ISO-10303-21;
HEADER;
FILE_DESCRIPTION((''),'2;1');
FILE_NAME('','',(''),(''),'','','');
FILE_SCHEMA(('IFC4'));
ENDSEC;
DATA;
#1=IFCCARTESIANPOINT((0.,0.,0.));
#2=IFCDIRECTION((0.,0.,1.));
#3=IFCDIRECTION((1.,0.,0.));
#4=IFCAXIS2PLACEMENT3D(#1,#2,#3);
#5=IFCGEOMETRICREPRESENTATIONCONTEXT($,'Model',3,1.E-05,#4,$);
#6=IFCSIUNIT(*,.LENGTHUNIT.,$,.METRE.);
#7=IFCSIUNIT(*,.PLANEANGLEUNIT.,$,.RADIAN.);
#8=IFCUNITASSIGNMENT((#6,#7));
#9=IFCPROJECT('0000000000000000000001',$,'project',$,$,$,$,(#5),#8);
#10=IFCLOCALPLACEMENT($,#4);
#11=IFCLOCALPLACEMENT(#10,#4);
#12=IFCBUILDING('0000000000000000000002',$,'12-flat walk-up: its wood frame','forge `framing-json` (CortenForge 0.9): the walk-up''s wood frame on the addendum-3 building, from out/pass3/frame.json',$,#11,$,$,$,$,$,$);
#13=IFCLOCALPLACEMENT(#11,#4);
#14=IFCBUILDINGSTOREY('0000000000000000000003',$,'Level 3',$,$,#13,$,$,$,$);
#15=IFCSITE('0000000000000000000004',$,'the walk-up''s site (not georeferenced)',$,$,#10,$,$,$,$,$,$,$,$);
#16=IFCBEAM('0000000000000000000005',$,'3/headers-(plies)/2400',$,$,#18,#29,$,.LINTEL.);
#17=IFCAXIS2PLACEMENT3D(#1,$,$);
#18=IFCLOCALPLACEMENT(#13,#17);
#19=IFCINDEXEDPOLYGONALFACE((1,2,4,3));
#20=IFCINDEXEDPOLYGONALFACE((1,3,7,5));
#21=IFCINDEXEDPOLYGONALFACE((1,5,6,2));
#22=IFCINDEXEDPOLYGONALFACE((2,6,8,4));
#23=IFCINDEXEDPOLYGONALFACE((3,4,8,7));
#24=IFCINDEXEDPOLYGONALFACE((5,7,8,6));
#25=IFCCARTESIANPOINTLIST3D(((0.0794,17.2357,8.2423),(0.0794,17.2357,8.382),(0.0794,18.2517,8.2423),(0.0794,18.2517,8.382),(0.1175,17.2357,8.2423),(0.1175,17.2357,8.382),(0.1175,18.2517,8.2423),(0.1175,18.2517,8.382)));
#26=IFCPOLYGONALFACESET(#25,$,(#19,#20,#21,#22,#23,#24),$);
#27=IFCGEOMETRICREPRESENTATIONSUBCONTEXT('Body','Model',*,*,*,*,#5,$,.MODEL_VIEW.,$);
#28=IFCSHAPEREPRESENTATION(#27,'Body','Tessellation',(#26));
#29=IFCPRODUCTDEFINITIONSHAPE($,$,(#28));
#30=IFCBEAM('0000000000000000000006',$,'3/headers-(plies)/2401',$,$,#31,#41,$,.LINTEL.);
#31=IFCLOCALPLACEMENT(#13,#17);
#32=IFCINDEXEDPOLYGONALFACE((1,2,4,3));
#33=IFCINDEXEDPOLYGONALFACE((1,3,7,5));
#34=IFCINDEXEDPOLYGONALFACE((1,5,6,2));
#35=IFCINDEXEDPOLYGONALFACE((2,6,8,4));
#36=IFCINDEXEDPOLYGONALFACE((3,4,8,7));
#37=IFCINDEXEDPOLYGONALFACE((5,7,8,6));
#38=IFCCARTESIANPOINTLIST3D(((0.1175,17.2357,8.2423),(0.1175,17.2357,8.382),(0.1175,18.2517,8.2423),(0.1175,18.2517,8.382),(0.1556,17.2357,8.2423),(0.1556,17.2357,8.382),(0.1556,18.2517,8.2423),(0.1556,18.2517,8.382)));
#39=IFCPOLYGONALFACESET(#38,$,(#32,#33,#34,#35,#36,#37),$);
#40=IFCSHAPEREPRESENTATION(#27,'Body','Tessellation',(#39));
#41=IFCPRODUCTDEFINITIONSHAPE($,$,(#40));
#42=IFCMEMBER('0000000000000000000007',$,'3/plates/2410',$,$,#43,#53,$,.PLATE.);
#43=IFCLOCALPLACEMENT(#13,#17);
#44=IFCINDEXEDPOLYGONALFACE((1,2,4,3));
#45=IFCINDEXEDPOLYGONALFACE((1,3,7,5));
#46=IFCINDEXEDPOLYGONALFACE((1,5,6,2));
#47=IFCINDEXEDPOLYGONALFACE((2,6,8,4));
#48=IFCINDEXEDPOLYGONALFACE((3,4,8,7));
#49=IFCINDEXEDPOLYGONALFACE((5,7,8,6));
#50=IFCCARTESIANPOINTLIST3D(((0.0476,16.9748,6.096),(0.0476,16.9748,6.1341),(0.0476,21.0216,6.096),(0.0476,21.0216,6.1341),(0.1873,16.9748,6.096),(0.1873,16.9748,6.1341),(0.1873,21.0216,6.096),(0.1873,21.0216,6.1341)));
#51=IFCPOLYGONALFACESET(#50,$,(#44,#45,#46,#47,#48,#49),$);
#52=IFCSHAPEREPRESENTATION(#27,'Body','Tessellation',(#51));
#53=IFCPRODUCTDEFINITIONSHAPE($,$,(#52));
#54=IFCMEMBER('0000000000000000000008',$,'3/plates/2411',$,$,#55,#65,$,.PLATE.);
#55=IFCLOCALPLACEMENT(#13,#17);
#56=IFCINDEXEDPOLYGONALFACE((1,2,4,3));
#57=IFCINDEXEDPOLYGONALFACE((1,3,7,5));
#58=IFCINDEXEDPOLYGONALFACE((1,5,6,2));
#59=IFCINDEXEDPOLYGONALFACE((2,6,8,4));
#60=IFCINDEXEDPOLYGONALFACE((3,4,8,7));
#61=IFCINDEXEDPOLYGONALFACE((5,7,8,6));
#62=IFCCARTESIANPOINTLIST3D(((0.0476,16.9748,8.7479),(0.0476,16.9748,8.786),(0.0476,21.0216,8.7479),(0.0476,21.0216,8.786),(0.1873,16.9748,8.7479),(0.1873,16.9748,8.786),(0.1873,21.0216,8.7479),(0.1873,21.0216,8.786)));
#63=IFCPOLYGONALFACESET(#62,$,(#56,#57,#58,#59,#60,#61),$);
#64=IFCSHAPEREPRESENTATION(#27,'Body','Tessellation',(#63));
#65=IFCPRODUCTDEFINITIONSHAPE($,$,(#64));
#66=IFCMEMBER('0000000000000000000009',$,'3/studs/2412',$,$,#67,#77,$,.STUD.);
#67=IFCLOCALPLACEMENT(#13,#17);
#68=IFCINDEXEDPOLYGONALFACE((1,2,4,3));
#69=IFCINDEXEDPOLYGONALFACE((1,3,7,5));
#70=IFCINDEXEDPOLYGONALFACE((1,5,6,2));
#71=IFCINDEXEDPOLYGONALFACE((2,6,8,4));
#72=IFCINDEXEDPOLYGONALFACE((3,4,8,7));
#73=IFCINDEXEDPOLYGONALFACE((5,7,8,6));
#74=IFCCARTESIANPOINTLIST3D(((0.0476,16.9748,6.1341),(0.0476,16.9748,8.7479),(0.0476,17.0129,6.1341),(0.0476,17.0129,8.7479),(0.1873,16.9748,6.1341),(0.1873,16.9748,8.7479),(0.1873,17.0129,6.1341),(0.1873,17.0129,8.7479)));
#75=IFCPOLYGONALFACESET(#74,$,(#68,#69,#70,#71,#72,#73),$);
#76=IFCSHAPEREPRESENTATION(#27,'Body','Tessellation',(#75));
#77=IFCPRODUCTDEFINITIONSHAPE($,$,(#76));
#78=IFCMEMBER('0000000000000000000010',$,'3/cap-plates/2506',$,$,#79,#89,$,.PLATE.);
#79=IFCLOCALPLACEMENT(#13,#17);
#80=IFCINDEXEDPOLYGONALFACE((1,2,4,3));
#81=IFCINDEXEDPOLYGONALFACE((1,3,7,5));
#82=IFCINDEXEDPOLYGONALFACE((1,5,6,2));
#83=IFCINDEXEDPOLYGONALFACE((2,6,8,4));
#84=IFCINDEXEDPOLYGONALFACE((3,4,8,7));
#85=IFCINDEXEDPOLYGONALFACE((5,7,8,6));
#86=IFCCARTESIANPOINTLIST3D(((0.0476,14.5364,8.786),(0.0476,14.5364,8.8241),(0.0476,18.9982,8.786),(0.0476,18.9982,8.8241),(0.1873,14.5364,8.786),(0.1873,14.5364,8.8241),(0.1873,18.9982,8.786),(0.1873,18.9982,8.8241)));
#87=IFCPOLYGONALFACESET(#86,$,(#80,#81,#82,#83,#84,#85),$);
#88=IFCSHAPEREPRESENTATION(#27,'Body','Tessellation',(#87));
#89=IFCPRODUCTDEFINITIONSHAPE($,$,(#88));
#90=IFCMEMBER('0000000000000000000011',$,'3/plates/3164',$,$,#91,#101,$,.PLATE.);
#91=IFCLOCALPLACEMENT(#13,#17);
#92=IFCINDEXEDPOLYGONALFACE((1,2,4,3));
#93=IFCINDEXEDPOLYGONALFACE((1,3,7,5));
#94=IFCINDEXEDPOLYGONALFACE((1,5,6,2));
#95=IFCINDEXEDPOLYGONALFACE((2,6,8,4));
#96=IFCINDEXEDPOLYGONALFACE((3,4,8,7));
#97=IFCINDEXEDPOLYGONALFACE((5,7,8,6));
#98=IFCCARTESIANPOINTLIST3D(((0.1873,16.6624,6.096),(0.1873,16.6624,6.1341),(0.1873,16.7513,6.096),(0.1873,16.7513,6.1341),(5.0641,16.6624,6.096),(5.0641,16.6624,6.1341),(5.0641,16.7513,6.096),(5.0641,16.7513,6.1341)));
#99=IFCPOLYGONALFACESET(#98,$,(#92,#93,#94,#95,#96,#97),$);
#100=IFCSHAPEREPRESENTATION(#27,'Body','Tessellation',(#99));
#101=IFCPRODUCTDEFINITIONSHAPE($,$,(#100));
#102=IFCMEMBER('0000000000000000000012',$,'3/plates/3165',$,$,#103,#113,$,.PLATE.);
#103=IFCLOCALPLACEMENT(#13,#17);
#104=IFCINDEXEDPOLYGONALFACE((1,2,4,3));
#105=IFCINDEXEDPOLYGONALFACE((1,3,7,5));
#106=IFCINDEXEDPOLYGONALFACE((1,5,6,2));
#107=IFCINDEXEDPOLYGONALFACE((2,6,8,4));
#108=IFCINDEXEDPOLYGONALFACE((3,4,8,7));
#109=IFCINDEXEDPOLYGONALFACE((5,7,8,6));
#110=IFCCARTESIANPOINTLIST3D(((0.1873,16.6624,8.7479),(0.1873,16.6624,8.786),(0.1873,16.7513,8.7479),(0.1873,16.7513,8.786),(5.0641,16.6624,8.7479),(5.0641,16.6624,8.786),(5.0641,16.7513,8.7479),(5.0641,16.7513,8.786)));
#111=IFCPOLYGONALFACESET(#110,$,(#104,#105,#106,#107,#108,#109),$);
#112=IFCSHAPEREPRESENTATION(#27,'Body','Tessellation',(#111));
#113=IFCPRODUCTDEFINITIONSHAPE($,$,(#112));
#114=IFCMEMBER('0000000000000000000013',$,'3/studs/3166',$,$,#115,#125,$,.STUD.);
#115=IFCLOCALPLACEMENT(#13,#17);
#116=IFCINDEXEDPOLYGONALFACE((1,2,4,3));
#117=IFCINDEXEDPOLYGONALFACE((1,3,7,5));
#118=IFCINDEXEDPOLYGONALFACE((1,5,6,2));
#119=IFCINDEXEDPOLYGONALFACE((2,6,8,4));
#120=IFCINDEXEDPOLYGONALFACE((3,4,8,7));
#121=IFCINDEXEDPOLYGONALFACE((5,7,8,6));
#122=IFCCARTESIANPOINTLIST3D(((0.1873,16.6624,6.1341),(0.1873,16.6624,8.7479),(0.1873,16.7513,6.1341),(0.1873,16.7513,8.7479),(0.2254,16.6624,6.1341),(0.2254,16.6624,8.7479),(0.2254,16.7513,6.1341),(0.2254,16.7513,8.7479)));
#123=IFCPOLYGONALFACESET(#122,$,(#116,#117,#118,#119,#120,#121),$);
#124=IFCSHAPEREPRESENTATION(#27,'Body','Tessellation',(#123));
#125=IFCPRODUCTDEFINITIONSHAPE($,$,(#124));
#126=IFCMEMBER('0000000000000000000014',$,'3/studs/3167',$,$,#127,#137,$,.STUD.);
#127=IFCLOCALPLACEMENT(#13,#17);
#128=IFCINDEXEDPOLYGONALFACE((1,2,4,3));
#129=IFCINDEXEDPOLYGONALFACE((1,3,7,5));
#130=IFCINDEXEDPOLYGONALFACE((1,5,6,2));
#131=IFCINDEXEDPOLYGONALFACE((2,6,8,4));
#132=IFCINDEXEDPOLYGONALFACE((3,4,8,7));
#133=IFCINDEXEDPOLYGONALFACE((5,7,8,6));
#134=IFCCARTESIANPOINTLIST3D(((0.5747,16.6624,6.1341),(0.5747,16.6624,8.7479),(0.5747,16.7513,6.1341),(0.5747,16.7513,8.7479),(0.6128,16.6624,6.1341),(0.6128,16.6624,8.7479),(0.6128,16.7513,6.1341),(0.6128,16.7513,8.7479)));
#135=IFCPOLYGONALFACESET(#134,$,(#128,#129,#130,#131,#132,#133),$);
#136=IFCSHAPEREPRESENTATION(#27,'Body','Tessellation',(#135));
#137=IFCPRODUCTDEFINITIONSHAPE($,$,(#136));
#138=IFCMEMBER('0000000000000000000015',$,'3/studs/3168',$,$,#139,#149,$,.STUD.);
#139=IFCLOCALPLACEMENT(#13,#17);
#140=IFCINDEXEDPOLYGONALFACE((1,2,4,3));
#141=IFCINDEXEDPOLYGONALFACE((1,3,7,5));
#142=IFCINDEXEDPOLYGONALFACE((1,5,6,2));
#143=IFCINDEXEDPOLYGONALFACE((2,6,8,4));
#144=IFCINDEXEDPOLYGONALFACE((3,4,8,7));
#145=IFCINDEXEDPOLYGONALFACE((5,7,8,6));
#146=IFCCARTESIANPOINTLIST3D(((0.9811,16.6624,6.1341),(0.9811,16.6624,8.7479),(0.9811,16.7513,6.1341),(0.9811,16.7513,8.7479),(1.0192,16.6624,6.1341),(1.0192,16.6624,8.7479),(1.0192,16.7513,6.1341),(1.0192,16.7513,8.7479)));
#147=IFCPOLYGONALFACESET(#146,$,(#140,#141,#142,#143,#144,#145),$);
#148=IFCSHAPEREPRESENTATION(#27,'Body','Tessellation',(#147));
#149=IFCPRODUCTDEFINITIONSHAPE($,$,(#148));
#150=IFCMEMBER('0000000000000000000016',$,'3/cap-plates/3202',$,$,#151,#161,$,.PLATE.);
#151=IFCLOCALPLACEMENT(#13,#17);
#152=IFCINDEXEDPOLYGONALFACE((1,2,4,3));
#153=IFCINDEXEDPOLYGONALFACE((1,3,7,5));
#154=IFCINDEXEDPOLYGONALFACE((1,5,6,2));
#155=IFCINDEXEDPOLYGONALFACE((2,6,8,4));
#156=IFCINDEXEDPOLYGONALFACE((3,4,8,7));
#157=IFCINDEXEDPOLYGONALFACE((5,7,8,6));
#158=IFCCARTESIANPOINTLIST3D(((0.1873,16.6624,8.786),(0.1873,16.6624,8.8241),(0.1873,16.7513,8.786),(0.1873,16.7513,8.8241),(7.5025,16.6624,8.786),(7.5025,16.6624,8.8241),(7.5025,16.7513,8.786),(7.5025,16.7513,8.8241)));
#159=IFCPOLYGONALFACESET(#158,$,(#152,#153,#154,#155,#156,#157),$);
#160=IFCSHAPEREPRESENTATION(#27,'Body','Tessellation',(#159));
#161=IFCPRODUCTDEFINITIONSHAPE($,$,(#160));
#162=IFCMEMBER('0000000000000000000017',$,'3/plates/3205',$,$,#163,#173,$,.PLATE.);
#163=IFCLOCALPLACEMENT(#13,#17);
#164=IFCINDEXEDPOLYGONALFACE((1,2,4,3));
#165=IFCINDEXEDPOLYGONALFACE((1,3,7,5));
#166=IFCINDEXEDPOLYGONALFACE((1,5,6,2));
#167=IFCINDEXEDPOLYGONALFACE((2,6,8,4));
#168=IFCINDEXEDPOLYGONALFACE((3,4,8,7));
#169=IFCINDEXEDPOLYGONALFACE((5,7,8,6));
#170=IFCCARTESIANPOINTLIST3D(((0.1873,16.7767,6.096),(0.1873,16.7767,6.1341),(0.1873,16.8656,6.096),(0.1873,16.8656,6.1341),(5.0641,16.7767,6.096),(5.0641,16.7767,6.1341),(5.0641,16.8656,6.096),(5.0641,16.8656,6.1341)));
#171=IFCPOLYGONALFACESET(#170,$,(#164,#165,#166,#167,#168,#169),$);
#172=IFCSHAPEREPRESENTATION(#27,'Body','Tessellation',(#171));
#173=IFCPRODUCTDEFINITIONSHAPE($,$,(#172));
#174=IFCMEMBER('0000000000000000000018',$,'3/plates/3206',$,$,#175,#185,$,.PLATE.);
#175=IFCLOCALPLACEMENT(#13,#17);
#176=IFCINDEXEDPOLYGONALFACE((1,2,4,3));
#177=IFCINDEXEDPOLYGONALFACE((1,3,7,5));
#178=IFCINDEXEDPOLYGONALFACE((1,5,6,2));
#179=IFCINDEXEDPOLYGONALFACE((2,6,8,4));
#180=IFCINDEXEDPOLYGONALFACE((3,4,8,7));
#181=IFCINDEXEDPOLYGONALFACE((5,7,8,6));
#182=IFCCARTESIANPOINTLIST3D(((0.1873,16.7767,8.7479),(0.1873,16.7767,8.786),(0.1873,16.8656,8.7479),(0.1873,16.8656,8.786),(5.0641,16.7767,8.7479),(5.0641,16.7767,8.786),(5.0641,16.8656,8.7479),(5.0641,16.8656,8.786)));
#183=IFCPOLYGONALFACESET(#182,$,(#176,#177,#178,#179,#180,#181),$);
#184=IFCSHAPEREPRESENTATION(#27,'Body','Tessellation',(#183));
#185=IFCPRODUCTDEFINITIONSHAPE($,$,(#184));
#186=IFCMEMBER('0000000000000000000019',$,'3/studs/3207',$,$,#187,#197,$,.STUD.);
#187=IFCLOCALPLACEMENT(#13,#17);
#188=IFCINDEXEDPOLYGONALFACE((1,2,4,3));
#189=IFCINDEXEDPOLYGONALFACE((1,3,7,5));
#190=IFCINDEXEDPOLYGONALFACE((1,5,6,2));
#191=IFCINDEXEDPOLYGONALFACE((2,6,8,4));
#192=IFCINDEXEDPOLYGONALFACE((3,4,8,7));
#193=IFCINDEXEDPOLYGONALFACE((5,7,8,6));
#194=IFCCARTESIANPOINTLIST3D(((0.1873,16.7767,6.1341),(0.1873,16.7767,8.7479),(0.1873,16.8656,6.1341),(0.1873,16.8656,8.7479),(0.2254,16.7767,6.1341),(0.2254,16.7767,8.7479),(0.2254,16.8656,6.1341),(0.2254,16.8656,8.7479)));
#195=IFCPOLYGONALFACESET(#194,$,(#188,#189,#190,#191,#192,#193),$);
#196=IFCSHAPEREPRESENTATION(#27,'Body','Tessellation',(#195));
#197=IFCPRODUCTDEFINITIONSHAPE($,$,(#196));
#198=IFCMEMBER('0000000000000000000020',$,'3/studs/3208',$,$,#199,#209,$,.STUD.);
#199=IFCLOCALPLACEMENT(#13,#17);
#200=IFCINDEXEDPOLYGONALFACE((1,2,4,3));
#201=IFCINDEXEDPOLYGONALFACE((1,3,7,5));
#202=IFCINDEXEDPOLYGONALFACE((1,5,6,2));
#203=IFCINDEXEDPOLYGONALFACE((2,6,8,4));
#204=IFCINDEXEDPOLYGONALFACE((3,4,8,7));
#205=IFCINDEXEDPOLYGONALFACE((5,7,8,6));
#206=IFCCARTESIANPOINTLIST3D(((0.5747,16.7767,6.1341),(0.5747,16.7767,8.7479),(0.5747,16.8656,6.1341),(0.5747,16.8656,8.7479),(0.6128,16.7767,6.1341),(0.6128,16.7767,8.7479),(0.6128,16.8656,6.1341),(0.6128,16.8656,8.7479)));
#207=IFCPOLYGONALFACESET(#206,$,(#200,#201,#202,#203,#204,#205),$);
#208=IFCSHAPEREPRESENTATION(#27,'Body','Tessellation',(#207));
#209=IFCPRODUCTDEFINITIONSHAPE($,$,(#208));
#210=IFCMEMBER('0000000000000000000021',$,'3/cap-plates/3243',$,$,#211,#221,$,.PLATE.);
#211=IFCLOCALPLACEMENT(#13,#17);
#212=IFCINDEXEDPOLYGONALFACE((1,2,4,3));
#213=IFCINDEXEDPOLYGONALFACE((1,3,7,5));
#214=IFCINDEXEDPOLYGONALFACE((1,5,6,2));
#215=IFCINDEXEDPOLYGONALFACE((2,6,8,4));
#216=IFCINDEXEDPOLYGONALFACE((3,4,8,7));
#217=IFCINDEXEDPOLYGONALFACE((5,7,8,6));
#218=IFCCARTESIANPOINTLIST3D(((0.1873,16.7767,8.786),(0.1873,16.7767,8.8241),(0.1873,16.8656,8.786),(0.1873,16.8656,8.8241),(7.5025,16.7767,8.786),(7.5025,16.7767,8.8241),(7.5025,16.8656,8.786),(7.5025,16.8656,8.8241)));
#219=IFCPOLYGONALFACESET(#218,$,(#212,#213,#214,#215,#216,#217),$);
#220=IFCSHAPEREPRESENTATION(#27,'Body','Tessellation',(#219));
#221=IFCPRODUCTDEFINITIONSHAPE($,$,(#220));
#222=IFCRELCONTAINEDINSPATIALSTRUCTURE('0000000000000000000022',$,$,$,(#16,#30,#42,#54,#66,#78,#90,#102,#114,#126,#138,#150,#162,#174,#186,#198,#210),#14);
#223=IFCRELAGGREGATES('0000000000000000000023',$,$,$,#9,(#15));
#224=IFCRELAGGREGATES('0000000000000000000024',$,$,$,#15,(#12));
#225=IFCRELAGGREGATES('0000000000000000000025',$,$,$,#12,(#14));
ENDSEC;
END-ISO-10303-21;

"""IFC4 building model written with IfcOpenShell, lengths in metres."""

from ifc_helpers import new_model, si_unit, frame, frame_2d, origin, origin_with_axes, place, context, subcontext, project, spatial, rectangle, extrude, element, save


model = new_model("IFC4")

# Units and contexts
model_context = context("Model", 3, precision=1e-05, world=origin_with_axes())
body_context = subcontext(model_context, "Body", "Model", "MODEL_VIEW")
ifc_project = project(units=[si_unit("LENGTHUNIT", "METRE"), si_unit("PLANEANGLEUNIT", "RADIAN")], contexts=[model_context])

# Site, building, storey
site_placement = place(None, origin_with_axes())
site = spatial("IfcSite", under=ifc_project, at=site_placement, Name="the walk-up's site (not georeferenced)")
building_placement = place(site_placement, origin_with_axes())
building = spatial("IfcBuilding", under=site, at=building_placement, Name="12-flat walk-up: its wood frame", Description="forge `framing-json` (CortenForge 0.9): the walk-up's wood frame on the addendum-3 building, from out/pass3/frame.json")
storey_placement = place(building_placement, origin_with_axes())
storey = spatial("IfcBuildingStorey", under=building, at=storey_placement, Name="Level 3")

# Beams
for number, where, z_axis, x_axis, name in (
    (1, (0.0794, 17.2357, 8.2423), (0.0, 0.0, 1.0), (1.0, 0.0, 0.0), "3/headers-(plies)/2400"),
    (2, (0.1175, 17.2357, 8.2423), (0.0, 0.0, 1.0), (1.0, 0.0, 0.0), "3/headers-(plies)/2401"),
):
    element("IfcBeam", number, at=place(storey_placement, frame(where, z_axis=z_axis, x_axis=x_axis)), inside=storey, Name=name, PredefinedType="LINTEL", context=body_context, shape_type="SweptSolid", body=[
        extrude(rectangle(XDim=0.0381, YDim=1.016, at=frame_2d((0.019, 0.508))), origin(), (0.0, 0.0, 1.0), 0.1397),
    ])

# Members
for number, where, z_axis, x_axis, name in (
    (3, (0.0476, 16.9748, 6.096), (0.0, 0.0, 1.0), (1.0, 0.0, 0.0), "3/plates/2410"),
    (4, (0.0476, 16.9748, 8.7479), (0.0, 0.0, 1.0), (1.0, 0.0, 0.0), "3/plates/2411"),
):
    element("IfcMember", number, at=place(storey_placement, frame(where, z_axis=z_axis, x_axis=x_axis)), inside=storey, Name=name, PredefinedType="PLATE", context=body_context, shape_type="SweptSolid", body=[
        extrude(rectangle(XDim=0.1397, YDim=4.0468, at=frame_2d((0.0698, 2.0234))), origin(), (0.0, 0.0, 1.0), 0.0381),
    ])
member_1_placement = place(storey_placement, frame((0.0476, 16.9748, 6.1341), z_axis=(0.0, 0.0, 1.0), x_axis=(1.0, 0.0, 0.0)))
element("IfcMember", 5, at=member_1_placement, inside=storey, Name="3/studs/2412", PredefinedType="STUD", context=body_context, shape_type="SweptSolid", body=[
    extrude(rectangle(XDim=0.1397, YDim=0.0381, at=frame_2d((0.0698, 0.0191))), origin(), (0.0, 0.0, 1.0), 2.6138),
])
member_2_placement = place(storey_placement, frame((0.0476, 14.5364, 8.786), z_axis=(0.0, 0.0, 1.0), x_axis=(1.0, 0.0, 0.0)))
element("IfcMember", 6, at=member_2_placement, inside=storey, Name="3/cap-plates/2506", PredefinedType="PLATE", context=body_context, shape_type="SweptSolid", body=[
    extrude(rectangle(XDim=0.1397, YDim=4.4618, at=frame_2d((0.0698, 2.2309))), origin(), (0.0, 0.0, 1.0), 0.0381),
])
for number, where, z_axis, x_axis, name in (
    (7, (0.1873, 16.6624, 6.096), (0.0, 0.0, 1.0), (1.0, 0.0, 0.0), "3/plates/3164"),
    (8, (0.1873, 16.6624, 8.7479), (0.0, 0.0, 1.0), (1.0, 0.0, 0.0), "3/plates/3165"),
):
    element("IfcMember", number, at=place(storey_placement, frame(where, z_axis=z_axis, x_axis=x_axis)), inside=storey, Name=name, PredefinedType="PLATE", context=body_context, shape_type="SweptSolid", body=[
        extrude(rectangle(XDim=4.8768, YDim=0.0889, at=frame_2d((2.4384, 0.0444))), origin(), (0.0, 0.0, 1.0), 0.0381),
    ])
member_3_placement = place(storey_placement, frame((0.1873, 16.6624, 6.1341), z_axis=(0.0, 0.0, 1.0), x_axis=(1.0, 0.0, 0.0)))
element("IfcMember", 9, at=member_3_placement, inside=storey, Name="3/studs/3166", PredefinedType="STUD", context=body_context, shape_type="SweptSolid", body=[
    extrude(rectangle(XDim=0.0381, YDim=0.0889, at=frame_2d((0.019, 0.0444))), origin(), (0.0, 0.0, 1.0), 2.6138),
])
for number, where, z_axis, x_axis, name in (
    (10, (0.5747, 16.6624, 6.1341), (0.0, 0.0, 1.0), (1.0, 0.0, 0.0), "3/studs/3167"),
    (11, (0.9811, 16.6624, 6.1341), (0.0, 0.0, 1.0), (1.0, 0.0, 0.0), "3/studs/3168"),
):
    element("IfcMember", number, at=place(storey_placement, frame(where, z_axis=z_axis, x_axis=x_axis)), inside=storey, Name=name, PredefinedType="STUD", context=body_context, shape_type="SweptSolid", body=[
        extrude(rectangle(XDim=0.0381, YDim=0.0889, at=frame_2d((0.019, 0.0444))), origin(), (0.0, 0.0, 1.0), 2.6138),
    ])
member_4_placement = place(storey_placement, frame((0.1873, 16.6624, 8.786), z_axis=(0.0, 0.0, 1.0), x_axis=(1.0, 0.0, 0.0)))
element("IfcMember", 12, at=member_4_placement, inside=storey, Name="3/cap-plates/3202", PredefinedType="PLATE", context=body_context, shape_type="SweptSolid", body=[
    extrude(rectangle(XDim=7.3152, YDim=0.0889, at=frame_2d((3.6576, 0.0444))), origin(), (0.0, 0.0, 1.0), 0.0381),
])
for number, where, z_axis, x_axis, name in (
    (13, (0.1873, 16.7767, 6.096), (0.0, 0.0, 1.0), (1.0, 0.0, 0.0), "3/plates/3205"),
    (14, (0.1873, 16.7767, 8.7479), (0.0, 0.0, 1.0), (1.0, 0.0, 0.0), "3/plates/3206"),
):
    element("IfcMember", number, at=place(storey_placement, frame(where, z_axis=z_axis, x_axis=x_axis)), inside=storey, Name=name, PredefinedType="PLATE", context=body_context, shape_type="SweptSolid", body=[
        extrude(rectangle(XDim=4.8768, YDim=0.0889, at=frame_2d((2.4384, 0.0444))), origin(), (0.0, 0.0, 1.0), 0.0381),
    ])
member_5_placement = place(storey_placement, frame((0.1873, 16.7767, 6.1341), z_axis=(0.0, 0.0, 1.0), x_axis=(1.0, 0.0, 0.0)))
element("IfcMember", 15, at=member_5_placement, inside=storey, Name="3/studs/3207", PredefinedType="STUD", context=body_context, shape_type="SweptSolid", body=[
    extrude(rectangle(XDim=0.0381, YDim=0.0889, at=frame_2d((0.019, 0.0444))), origin(), (0.0, 0.0, 1.0), 2.6138),
])
member_6_placement = place(storey_placement, frame((0.5747, 16.7767, 6.1341), z_axis=(0.0, 0.0, 1.0), x_axis=(1.0, 0.0, 0.0)))
element("IfcMember", 16, at=member_6_placement, inside=storey, Name="3/studs/3208", PredefinedType="STUD", context=body_context, shape_type="SweptSolid", body=[
    extrude(rectangle(XDim=0.0381, YDim=0.0889, at=frame_2d((0.019, 0.0444))), origin(), (0.0, 0.0, 1.0), 2.6138),
])
member_7_placement = place(storey_placement, frame((0.1873, 16.7767, 8.786), z_axis=(0.0, 0.0, 1.0), x_axis=(1.0, 0.0, 0.0)))
element("IfcMember", 17, at=member_7_placement, inside=storey, Name="3/cap-plates/3243", PredefinedType="PLATE", context=body_context, shape_type="SweptSolid", body=[
    extrude(rectangle(XDim=7.3152, YDim=0.0889, at=frame_2d((3.6576, 0.0444))), origin(), (0.0, 0.0, 1.0), 0.0381),
])

save(model, "model.ifc")
